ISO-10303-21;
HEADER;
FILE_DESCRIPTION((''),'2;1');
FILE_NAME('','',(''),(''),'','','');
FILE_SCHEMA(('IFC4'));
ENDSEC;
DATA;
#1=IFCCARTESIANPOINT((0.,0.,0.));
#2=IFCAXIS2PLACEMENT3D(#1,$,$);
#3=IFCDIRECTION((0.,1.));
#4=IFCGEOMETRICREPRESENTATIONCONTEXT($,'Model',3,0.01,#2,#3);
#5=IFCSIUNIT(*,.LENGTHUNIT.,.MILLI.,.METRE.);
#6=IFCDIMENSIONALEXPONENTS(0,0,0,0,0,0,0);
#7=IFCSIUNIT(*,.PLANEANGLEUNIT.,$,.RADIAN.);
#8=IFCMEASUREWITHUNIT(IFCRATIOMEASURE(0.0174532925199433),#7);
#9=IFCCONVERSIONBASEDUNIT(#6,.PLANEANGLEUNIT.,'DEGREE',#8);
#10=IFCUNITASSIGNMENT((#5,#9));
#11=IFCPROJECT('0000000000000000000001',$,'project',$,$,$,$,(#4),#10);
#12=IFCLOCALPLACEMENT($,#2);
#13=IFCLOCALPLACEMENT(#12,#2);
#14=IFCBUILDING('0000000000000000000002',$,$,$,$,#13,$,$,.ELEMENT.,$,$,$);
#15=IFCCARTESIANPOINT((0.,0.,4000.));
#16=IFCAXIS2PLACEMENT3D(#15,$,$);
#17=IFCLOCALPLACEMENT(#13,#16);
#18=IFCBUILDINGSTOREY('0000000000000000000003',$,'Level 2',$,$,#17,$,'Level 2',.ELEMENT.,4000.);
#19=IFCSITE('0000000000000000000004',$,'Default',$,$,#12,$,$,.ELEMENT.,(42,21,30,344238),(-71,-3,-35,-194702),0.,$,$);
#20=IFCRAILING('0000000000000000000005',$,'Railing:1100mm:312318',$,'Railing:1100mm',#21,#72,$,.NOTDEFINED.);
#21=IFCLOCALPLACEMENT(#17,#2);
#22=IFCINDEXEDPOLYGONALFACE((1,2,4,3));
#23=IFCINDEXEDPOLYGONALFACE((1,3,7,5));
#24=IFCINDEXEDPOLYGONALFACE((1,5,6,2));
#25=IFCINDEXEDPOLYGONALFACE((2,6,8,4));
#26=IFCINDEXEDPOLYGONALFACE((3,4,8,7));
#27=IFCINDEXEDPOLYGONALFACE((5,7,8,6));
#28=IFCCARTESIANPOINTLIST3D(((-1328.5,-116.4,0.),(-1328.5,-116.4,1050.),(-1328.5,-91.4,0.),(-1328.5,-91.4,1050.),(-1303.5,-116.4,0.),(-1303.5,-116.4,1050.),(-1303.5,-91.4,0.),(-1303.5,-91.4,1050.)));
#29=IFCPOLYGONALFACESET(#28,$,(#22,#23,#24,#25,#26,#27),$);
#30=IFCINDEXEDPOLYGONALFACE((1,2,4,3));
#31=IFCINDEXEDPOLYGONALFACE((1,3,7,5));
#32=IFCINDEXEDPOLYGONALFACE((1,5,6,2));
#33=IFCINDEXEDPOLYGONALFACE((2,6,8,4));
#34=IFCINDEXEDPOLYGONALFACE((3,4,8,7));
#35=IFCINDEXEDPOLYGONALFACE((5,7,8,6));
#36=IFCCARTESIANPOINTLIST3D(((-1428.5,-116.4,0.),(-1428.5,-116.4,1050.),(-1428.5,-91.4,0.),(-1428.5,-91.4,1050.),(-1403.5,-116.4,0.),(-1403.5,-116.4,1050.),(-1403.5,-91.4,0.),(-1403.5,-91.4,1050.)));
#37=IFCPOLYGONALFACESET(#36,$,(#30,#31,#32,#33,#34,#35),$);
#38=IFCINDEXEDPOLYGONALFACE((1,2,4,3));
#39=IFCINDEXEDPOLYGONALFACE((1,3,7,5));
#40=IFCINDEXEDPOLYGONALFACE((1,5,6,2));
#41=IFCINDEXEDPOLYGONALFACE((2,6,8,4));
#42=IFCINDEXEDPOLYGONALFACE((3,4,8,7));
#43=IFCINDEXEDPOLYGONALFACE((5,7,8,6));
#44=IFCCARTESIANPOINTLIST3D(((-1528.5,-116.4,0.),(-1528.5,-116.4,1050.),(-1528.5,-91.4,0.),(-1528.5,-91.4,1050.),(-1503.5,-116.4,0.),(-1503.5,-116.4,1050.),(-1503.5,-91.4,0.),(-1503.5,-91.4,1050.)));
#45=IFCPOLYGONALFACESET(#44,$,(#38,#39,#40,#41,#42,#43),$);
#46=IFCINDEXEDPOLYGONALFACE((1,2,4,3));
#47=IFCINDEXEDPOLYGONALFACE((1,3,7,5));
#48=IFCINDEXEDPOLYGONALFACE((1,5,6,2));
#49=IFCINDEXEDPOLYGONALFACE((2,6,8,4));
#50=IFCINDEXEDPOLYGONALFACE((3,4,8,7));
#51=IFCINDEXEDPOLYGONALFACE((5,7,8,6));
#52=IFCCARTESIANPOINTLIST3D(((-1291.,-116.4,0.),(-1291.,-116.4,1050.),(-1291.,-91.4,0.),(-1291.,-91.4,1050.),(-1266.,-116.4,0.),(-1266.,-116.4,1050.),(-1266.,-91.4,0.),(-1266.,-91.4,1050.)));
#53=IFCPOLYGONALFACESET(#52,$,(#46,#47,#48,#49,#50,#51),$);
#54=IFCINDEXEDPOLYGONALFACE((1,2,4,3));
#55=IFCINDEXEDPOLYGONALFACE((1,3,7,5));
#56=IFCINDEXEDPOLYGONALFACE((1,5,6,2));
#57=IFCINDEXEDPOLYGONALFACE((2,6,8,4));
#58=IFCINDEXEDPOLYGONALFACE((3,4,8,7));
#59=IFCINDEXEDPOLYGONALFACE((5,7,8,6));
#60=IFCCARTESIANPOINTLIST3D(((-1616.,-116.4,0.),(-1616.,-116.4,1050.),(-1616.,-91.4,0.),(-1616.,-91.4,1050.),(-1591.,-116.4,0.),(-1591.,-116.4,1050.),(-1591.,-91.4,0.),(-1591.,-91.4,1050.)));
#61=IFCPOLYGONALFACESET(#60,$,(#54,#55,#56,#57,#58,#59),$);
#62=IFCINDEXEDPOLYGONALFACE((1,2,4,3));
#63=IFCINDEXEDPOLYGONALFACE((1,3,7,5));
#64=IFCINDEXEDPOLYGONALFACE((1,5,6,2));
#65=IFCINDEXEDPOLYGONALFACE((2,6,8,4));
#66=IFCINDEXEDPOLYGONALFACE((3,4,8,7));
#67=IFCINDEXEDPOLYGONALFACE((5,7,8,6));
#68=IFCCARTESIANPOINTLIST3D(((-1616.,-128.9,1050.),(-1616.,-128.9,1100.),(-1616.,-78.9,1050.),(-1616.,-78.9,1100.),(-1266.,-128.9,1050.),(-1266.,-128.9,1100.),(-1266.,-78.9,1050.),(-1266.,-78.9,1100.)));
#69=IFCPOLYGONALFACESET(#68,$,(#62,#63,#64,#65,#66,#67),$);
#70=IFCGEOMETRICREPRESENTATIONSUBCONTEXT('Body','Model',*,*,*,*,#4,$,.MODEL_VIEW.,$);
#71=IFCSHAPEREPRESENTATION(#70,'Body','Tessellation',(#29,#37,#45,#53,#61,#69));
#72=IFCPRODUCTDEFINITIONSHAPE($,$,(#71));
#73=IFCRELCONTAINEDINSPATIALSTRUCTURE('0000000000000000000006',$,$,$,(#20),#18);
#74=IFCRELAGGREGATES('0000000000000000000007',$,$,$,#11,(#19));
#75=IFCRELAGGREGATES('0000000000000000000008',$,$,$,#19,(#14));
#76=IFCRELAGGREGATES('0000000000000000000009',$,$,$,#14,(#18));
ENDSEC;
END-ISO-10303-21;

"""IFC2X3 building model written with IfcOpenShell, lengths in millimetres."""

from ifc_helpers import new_model, entity, si_unit, converted_unit, direction, frame, frame_2d, origin, origin_2d_with_axis, place, context, subcontext, project, spatial, rectangle, extrude, element, save


model = new_model("IFC2X3")

# Units and contexts
model_context = context("Model", 3, precision=0.01, world=origin(), true_north=direction((0.0, 1.0)))
body_context = subcontext(model_context, "Body", "Model", "MODEL_VIEW")
ifc_project = project(units=[si_unit("LENGTHUNIT", "METRE", prefix="MILLI"), converted_unit("PLANEANGLEUNIT", "DEGREE", entity("IfcRatioMeasure", 0.0174532925199433), si_unit("PLANEANGLEUNIT", "RADIAN"), dimensions=[0, 0, 0, 0, 0, 0, 0])], contexts=[model_context])

# Site, building, storey
site_placement = place(None, origin())
site = spatial("IfcSite", under=ifc_project, at=site_placement, Name="Default", CompositionType="ELEMENT", RefLatitude=(42, 21, 30, 344238), RefLongitude=(-71, -3, -35, -194702), RefElevation=0.0)
building_placement = place(site_placement, origin())
building = spatial("IfcBuilding", under=site, at=building_placement, CompositionType="ELEMENT")
storey_placement = place(building_placement, frame((0.0, 0.0, 4000.0)))
storey = spatial("IfcBuildingStorey", under=building, at=storey_placement, Name="Level 2", LongName="Level 2", CompositionType="ELEMENT", Elevation=4000.0)

# Railing
railing_1_placement = place(storey_placement, origin())
element("IfcRailing", 1, at=railing_1_placement, inside=storey, Name="Railing:1100mm:312318", ObjectType="Railing:1100mm", PredefinedType="NOTDEFINED", context=body_context, shape_type="SweptSolid", body=[
    extrude(rectangle(XDim=25.0, YDim=25.0, at=origin_2d_with_axis()), frame((-1316.0, -103.9, 0.0)), (0.0, 0.0, 1.0), 1050.0),
    extrude(rectangle(XDim=25.0, YDim=25.0, at=origin_2d_with_axis()), frame((-1416.0, -103.9, 0.0)), (0.0, 0.0, 1.0), 1050.0),
    extrude(rectangle(XDim=25.0, YDim=25.0, at=origin_2d_with_axis()), frame((-1516.0, -103.9, 0.0)), (0.0, 0.0, 1.0), 1050.0),
    extrude(rectangle(XDim=25.0, YDim=25.0, at=origin_2d_with_axis()), frame((-1278.5, -103.9, 0.0)), (0.0, 0.0, 1.0), 1050.0),
    extrude(rectangle(XDim=25.0, YDim=25.0, at=origin_2d_with_axis()), frame((-1603.5, -103.9, 0.0)), (0.0, 0.0, 1.0), 1050.0),
    extrude(rectangle(XDim=350.0, YDim=50.0, at=frame_2d((0.0, 0.0), x_axis=(1.0, 0.0))), frame((-1441.0, -103.9, 1050.0)), (0.0, 0.0, 1.0), 50.0),
])

save(model, "model.ifc")
